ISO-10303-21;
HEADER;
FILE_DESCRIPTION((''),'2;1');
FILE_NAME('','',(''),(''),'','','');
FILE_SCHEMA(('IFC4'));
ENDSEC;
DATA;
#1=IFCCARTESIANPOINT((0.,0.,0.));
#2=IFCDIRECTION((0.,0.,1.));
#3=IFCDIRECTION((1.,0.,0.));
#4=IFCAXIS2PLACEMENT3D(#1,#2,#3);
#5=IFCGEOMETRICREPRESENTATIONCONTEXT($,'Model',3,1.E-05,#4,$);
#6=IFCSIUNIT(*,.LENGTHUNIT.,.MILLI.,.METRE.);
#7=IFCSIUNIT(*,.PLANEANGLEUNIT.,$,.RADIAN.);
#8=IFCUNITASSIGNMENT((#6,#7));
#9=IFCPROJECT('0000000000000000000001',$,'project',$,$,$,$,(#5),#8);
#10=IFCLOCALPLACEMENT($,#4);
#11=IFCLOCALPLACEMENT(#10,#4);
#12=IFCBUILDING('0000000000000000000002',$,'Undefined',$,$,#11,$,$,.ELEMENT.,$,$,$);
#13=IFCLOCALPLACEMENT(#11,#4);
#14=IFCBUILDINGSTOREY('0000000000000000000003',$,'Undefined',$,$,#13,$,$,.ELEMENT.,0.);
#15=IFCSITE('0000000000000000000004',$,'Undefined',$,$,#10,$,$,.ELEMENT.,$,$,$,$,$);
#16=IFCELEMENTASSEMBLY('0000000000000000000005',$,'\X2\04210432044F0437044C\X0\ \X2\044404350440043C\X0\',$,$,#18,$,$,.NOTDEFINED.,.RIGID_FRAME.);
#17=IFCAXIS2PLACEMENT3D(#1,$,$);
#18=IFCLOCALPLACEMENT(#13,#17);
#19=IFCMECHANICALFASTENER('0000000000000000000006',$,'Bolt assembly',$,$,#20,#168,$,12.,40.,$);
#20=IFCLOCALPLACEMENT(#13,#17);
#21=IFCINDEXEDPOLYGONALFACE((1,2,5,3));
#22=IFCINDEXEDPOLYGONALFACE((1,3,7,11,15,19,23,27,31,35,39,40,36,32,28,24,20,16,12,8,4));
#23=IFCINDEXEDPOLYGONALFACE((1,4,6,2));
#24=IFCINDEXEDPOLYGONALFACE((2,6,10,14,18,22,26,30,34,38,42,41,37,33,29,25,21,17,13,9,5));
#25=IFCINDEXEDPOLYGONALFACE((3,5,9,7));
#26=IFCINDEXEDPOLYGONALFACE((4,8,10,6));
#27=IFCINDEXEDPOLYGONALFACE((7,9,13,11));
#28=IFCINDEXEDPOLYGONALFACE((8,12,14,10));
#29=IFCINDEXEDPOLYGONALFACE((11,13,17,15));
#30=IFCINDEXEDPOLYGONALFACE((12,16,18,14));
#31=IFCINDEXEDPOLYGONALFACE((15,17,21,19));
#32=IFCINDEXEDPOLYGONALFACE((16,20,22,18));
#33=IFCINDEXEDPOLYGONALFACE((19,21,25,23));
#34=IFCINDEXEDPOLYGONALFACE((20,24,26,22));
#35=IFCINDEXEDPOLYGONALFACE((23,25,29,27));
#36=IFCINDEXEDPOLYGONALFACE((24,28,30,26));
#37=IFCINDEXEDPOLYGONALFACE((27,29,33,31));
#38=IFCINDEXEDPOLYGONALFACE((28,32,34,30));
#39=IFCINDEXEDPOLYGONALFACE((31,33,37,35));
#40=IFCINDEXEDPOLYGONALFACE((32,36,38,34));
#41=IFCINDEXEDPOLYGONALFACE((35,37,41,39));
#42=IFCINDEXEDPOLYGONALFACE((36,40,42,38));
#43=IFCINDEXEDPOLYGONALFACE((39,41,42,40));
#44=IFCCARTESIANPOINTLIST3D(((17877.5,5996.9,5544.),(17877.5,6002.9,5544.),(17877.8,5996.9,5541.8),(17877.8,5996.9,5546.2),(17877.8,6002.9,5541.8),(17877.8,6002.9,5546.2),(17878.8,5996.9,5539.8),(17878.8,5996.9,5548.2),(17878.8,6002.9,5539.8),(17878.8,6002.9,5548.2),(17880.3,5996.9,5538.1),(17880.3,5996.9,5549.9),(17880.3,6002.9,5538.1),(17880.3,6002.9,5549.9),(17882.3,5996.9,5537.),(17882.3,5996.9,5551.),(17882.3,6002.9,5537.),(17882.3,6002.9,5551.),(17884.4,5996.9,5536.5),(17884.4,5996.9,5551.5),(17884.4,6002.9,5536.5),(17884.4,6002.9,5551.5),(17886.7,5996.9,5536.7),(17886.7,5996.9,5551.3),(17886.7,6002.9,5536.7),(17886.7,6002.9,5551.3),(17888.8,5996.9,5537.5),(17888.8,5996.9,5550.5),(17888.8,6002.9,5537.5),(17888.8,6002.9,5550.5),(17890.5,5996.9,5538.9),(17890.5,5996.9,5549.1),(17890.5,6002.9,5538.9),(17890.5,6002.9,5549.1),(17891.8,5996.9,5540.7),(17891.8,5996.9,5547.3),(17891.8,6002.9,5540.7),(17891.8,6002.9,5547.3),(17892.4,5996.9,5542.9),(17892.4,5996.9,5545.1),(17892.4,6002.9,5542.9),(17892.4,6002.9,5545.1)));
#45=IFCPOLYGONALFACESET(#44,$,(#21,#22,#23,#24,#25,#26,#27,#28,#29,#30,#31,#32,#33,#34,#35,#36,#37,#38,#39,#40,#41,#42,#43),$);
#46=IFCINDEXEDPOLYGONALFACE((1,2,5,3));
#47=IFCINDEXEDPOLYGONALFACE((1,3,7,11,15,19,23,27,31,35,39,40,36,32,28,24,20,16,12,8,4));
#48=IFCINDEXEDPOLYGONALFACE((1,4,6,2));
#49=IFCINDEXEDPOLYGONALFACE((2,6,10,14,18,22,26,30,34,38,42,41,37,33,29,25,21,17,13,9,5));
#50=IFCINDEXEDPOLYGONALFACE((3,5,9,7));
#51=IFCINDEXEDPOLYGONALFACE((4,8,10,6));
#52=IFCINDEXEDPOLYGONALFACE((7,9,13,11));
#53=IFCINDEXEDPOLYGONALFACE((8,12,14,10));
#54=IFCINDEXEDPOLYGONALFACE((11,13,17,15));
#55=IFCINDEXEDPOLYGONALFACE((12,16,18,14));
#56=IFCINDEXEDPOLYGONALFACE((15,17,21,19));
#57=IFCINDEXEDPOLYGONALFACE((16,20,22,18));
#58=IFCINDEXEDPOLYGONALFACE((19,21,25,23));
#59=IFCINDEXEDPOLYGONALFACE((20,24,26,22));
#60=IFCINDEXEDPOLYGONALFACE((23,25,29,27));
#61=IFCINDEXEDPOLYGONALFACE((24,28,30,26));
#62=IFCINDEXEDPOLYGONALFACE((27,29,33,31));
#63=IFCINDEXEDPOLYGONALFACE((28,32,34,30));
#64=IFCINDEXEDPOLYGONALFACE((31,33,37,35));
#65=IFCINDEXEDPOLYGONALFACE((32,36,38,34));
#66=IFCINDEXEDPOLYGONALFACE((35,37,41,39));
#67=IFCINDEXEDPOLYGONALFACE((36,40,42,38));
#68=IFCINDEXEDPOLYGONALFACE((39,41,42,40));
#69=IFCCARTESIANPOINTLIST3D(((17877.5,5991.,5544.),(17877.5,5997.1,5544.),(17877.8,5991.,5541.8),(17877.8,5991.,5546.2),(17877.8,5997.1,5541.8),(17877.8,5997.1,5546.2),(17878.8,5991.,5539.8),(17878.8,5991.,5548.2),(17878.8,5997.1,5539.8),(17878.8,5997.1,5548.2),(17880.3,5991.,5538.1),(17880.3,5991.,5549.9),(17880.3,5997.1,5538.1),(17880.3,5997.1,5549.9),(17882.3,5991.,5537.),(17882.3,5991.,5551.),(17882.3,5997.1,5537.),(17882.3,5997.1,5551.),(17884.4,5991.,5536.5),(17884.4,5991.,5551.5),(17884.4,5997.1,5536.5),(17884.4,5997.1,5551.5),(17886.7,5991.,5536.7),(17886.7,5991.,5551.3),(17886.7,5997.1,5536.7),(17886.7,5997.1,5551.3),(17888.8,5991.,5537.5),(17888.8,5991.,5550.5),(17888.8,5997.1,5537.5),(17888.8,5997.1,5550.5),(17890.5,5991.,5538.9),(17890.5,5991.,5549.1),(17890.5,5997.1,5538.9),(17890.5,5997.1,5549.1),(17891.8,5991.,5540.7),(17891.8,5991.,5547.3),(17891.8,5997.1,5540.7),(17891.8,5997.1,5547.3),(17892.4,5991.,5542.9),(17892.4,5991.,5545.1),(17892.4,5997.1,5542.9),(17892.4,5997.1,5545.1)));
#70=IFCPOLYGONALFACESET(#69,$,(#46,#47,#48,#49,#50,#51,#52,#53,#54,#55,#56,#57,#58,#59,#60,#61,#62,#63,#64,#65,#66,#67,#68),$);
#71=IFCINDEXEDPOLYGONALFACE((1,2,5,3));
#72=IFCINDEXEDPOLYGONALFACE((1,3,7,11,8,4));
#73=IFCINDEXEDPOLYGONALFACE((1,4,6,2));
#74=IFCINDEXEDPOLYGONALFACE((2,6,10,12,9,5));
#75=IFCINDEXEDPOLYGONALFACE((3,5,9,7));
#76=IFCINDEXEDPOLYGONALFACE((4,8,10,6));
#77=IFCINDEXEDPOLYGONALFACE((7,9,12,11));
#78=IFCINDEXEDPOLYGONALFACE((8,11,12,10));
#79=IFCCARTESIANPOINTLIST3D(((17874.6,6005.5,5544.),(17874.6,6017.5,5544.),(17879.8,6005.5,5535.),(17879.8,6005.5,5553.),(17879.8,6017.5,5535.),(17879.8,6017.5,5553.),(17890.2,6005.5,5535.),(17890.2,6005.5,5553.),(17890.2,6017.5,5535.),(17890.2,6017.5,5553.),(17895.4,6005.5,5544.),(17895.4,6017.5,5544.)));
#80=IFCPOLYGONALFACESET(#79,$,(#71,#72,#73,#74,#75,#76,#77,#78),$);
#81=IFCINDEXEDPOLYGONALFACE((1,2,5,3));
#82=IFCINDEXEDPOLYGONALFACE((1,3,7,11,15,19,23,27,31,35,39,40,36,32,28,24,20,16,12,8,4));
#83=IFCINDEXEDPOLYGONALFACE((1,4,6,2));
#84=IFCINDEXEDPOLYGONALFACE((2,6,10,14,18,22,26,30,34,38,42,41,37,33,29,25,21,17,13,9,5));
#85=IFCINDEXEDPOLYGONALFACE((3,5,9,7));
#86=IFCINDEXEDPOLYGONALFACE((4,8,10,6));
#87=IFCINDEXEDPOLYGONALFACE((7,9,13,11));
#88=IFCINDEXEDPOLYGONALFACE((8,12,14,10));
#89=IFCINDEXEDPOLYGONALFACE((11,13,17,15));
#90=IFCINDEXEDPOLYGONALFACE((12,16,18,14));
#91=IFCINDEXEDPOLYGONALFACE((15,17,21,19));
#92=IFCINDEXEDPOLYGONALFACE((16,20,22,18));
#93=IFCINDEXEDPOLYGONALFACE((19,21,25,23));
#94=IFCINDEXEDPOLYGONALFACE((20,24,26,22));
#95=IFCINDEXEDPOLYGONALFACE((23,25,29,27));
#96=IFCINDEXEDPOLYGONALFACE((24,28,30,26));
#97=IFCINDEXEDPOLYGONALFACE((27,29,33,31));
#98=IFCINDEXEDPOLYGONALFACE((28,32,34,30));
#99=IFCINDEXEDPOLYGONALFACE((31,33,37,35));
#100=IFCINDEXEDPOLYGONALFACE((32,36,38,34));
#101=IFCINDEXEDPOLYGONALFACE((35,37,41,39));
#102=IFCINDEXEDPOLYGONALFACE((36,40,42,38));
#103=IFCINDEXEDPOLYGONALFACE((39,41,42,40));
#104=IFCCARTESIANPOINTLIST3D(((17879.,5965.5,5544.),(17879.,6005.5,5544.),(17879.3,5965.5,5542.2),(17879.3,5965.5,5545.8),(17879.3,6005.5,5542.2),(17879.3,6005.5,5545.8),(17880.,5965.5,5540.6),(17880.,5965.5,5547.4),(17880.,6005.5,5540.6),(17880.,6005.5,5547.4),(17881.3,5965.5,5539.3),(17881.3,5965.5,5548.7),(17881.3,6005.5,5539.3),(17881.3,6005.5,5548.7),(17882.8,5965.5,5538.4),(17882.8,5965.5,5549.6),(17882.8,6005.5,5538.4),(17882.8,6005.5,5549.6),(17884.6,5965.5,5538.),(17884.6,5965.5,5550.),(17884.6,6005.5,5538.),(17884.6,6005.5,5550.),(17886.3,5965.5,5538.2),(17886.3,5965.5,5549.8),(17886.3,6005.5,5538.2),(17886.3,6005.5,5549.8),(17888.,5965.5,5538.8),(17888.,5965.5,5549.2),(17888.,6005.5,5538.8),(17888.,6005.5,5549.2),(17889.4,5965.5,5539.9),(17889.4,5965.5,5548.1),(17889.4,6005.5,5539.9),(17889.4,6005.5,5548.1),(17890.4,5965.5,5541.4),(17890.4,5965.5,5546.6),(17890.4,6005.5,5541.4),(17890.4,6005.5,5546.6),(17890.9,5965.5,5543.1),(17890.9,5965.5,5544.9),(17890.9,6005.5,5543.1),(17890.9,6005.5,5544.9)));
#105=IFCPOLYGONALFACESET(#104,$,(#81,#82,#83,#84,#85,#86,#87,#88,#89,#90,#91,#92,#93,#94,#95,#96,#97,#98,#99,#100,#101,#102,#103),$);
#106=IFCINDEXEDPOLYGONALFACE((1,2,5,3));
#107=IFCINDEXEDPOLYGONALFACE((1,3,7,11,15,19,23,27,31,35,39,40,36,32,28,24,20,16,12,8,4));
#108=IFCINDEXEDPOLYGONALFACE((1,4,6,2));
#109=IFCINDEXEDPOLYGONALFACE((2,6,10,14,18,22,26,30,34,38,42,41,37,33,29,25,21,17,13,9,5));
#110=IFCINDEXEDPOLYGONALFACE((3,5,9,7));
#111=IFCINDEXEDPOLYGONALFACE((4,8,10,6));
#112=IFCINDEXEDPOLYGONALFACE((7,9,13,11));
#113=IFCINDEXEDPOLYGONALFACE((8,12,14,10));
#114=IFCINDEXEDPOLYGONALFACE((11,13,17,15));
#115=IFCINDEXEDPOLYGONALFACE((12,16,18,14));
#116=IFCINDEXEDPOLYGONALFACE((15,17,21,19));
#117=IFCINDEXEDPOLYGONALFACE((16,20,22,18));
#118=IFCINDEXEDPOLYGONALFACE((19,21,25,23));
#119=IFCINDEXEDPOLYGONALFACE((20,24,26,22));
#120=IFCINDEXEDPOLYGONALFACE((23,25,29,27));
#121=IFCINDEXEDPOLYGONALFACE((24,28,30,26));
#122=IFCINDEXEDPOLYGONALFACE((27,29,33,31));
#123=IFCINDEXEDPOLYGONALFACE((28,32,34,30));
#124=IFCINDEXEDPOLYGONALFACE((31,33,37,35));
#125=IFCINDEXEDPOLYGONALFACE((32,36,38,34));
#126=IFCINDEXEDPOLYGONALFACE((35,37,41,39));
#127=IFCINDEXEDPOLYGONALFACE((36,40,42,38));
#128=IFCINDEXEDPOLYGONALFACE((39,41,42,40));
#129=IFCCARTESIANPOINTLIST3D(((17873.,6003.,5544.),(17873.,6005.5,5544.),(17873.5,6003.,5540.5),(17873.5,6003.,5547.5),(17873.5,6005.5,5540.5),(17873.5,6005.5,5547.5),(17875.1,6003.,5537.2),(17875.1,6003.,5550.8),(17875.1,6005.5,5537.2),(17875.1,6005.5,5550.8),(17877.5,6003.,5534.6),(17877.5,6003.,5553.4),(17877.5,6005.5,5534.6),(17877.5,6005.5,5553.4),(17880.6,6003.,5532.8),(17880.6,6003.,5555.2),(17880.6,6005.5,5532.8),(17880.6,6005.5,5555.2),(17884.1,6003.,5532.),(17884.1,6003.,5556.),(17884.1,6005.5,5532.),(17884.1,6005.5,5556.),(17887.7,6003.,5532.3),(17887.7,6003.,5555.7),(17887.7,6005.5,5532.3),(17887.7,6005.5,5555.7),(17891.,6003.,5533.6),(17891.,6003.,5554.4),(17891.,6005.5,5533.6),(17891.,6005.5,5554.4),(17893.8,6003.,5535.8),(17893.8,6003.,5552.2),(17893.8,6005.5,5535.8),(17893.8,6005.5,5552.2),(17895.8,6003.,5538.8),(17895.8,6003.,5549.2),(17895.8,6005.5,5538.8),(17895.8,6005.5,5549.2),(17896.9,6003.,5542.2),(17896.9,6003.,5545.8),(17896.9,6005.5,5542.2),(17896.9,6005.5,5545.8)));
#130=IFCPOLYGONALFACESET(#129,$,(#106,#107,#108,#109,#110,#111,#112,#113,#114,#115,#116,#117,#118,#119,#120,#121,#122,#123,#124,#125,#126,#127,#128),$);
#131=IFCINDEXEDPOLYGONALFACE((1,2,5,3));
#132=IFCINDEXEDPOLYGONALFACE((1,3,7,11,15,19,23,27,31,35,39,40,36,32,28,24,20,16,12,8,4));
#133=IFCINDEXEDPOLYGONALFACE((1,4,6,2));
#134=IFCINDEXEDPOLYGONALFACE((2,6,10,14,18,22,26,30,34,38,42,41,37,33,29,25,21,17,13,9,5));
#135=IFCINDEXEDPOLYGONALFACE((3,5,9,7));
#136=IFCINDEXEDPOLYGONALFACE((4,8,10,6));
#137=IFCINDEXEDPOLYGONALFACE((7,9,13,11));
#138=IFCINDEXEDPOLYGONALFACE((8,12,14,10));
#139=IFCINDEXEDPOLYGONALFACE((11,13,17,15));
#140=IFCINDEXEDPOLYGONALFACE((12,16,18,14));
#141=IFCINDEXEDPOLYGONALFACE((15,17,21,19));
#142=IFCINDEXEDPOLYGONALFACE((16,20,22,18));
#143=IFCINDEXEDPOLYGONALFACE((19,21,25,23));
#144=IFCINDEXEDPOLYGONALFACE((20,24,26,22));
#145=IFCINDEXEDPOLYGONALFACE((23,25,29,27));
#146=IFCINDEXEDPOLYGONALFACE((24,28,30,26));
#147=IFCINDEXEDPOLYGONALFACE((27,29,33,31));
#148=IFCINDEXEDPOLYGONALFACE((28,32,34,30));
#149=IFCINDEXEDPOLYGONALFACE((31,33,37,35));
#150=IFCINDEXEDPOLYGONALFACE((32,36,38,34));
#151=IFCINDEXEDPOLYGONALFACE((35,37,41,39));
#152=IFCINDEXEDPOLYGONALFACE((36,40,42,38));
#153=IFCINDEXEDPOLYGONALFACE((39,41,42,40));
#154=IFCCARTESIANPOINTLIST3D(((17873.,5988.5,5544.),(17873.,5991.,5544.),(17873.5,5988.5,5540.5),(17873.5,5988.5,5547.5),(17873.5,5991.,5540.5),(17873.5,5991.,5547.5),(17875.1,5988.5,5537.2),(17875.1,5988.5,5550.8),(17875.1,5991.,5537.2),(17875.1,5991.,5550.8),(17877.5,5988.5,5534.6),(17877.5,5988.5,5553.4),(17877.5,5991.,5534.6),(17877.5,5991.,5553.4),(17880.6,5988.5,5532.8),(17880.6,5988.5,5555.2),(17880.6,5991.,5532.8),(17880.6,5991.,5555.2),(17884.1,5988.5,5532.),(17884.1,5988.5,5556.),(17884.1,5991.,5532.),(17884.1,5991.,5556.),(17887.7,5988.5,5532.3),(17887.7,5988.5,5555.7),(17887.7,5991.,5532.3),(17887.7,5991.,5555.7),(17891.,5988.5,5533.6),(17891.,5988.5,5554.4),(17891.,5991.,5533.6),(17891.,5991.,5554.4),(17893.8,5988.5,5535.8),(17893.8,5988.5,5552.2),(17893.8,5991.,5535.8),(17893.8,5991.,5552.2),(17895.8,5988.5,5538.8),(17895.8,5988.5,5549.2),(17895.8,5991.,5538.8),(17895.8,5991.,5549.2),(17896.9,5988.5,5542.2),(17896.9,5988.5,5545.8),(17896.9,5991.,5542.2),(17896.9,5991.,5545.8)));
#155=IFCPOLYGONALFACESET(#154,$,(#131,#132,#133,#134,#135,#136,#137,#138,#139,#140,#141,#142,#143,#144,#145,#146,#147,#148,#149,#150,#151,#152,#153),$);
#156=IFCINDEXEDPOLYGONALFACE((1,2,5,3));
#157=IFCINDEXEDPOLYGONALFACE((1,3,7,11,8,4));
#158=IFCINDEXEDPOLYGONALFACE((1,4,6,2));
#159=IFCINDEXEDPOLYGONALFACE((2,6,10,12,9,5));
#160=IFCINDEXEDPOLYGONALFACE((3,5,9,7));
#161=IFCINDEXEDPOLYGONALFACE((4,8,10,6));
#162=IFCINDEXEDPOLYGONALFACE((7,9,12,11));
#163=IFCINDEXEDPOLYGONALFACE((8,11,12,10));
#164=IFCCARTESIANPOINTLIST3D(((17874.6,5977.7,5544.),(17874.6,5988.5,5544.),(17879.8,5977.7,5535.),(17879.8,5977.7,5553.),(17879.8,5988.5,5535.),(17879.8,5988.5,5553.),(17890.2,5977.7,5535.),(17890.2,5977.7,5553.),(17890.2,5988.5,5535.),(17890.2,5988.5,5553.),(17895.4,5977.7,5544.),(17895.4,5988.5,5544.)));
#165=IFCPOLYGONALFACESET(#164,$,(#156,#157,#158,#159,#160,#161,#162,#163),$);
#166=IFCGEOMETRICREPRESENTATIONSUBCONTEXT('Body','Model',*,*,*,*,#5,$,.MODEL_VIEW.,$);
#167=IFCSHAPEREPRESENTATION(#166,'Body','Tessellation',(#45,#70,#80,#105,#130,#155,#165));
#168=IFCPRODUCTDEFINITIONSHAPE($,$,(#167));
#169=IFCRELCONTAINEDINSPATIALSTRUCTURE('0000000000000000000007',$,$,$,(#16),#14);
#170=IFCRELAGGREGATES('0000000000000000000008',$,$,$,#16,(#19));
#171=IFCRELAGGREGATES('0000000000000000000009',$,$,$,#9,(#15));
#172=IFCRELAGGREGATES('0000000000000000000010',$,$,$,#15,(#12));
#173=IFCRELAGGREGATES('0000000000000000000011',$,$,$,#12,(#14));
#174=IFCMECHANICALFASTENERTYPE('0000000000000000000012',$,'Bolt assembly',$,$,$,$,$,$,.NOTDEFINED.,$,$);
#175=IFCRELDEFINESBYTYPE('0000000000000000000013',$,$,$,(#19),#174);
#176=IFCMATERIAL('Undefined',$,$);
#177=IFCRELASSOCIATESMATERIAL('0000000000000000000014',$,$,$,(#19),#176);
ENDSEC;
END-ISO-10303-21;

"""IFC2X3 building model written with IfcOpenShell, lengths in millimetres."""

from ifc_helpers import new_model, si_unit, frame, origin_with_axes, origin_2d_with_axis, place, context, subcontext, project, spatial, polyline, circle, outline, extrude, source, transform, mapped, material, type_object, element, aggregate, save


model = new_model("IFC2X3")

# Units and contexts
model_context = context("Model", 3, precision=1e-05, world=origin_with_axes())
body_context = subcontext(model_context, "Body", "Model", "MODEL_VIEW")
ifc_project = project(units=[si_unit("LENGTHUNIT", "METRE", prefix="MILLI"), si_unit("PLANEANGLEUNIT", "RADIAN")], contexts=[model_context])

# Site, building, storey
site_placement = place(None, origin_with_axes())
site = spatial("IfcSite", under=ifc_project, at=site_placement, Name="Undefined", CompositionType="ELEMENT")
building_placement = place(site_placement, origin_with_axes())
building = spatial("IfcBuilding", under=site, at=building_placement, Name="Undefined", CompositionType="ELEMENT")
storey_placement = place(building_placement, origin_with_axes())
storey = spatial("IfcBuildingStorey", under=building, at=storey_placement, Name="Undefined", CompositionType="ELEMENT", Elevation=0.0)

# Element assembly
assembly_1_placement = place(storey_placement, origin_with_axes())
assembly_1 = element("IfcElementAssembly", 1, at=assembly_1_placement, inside=storey, Name="Связь ферм", AssemblyPlace="NOTDEFINED", PredefinedType="RIGID_FRAME")

# Mechanical fastener
ifc_material_1 = material(Name="Undefined")
mechanical_fastener_type = type_object("IfcMechanicalFastenerType", Name="Bolt assembly")
shared_shape_1 = source(origin_with_axes(), body_context, "Body", "SweptSolid", [
    extrude(circle(Radius=7.5, at=origin_2d_with_axis()), frame((0.0, 0.1, 0.0), z_axis=(0.0, 1.0, 0.0), x_axis=(1.0, 0.0, 0.0)), (0.0, 0.0, 1.0), 6.0),
    extrude(circle(Radius=7.5, at=origin_2d_with_axis()), frame((0.0, 5.9, 0.0), z_axis=(0.0, 1.0, 0.0), x_axis=(1.0, 0.0, 0.0)), (0.0, 0.0, 1.0), 6.1),
    extrude(outline(polyline([(10.4, 0.0), (5.2, 9.0), (-5.2, 9.0), (-10.4, 0.0), (-5.2, -9.0), (5.2, -9.0), (10.4, 0.0)])), frame((0.0, -14.5, 0.0), z_axis=(0.0, 1.0, 0.0), x_axis=(1.0, 0.0, 0.0)), (0.0, 0.0, 1.0), 12.0),
    extrude(circle(Radius=6.0, at=origin_2d_with_axis()), frame((0.0, -2.5, 0.0), z_axis=(0.0, 1.0, 0.0), x_axis=(1.0, 0.0, 0.0)), (0.0, 0.0, 1.0), 40.0),
    extrude(circle(Radius=12.0, at=origin_2d_with_axis()), frame((0.0, -2.5, 0.0), z_axis=(0.0, 1.0, 0.0), x_axis=(1.0, 0.0, 0.0)), (0.0, 0.0, 1.0), 2.5),
    extrude(circle(Radius=12.0, at=origin_2d_with_axis()), frame((0.0, 12.0, 0.0), z_axis=(0.0, 1.0, 0.0), x_axis=(1.0, 0.0, 0.0)), (0.0, 0.0, 1.0), 2.5),
    extrude(outline(polyline([(10.4, 0.0), (5.2, 9.0), (-5.2, 9.0), (-10.4, 0.0), (-5.2, -9.0), (5.2, -9.0), (10.4, 0.0)])), frame((0.0, 14.5, 0.0), z_axis=(0.0, 1.0, 0.0), x_axis=(1.0, 0.0, 0.0)), (0.0, 0.0, 1.0), 10.8),
])
mechanical_fastener_1_placement = place(assembly_1_placement, frame((17885.0, 6003.0, 5544.0), z_axis=(0.0, 0.0, 1.0), x_axis=(-1.0, 0.0, 0.0)))
mechanical_fastener_1 = element("IfcMechanicalFastener", 2, at=mechanical_fastener_1_placement, type_object=mechanical_fastener_type, material=ifc_material_1, Name="Bolt assembly", NominalDiameter=12.0, NominalLength=40.0, context=body_context, shape_type="MappedRepresentation", body=[
    mapped(shared_shape_1, transform((0.0, 0.0, 0.0))),
])
aggregate(assembly_1, [mechanical_fastener_1])

save(model, "model.ifc")
